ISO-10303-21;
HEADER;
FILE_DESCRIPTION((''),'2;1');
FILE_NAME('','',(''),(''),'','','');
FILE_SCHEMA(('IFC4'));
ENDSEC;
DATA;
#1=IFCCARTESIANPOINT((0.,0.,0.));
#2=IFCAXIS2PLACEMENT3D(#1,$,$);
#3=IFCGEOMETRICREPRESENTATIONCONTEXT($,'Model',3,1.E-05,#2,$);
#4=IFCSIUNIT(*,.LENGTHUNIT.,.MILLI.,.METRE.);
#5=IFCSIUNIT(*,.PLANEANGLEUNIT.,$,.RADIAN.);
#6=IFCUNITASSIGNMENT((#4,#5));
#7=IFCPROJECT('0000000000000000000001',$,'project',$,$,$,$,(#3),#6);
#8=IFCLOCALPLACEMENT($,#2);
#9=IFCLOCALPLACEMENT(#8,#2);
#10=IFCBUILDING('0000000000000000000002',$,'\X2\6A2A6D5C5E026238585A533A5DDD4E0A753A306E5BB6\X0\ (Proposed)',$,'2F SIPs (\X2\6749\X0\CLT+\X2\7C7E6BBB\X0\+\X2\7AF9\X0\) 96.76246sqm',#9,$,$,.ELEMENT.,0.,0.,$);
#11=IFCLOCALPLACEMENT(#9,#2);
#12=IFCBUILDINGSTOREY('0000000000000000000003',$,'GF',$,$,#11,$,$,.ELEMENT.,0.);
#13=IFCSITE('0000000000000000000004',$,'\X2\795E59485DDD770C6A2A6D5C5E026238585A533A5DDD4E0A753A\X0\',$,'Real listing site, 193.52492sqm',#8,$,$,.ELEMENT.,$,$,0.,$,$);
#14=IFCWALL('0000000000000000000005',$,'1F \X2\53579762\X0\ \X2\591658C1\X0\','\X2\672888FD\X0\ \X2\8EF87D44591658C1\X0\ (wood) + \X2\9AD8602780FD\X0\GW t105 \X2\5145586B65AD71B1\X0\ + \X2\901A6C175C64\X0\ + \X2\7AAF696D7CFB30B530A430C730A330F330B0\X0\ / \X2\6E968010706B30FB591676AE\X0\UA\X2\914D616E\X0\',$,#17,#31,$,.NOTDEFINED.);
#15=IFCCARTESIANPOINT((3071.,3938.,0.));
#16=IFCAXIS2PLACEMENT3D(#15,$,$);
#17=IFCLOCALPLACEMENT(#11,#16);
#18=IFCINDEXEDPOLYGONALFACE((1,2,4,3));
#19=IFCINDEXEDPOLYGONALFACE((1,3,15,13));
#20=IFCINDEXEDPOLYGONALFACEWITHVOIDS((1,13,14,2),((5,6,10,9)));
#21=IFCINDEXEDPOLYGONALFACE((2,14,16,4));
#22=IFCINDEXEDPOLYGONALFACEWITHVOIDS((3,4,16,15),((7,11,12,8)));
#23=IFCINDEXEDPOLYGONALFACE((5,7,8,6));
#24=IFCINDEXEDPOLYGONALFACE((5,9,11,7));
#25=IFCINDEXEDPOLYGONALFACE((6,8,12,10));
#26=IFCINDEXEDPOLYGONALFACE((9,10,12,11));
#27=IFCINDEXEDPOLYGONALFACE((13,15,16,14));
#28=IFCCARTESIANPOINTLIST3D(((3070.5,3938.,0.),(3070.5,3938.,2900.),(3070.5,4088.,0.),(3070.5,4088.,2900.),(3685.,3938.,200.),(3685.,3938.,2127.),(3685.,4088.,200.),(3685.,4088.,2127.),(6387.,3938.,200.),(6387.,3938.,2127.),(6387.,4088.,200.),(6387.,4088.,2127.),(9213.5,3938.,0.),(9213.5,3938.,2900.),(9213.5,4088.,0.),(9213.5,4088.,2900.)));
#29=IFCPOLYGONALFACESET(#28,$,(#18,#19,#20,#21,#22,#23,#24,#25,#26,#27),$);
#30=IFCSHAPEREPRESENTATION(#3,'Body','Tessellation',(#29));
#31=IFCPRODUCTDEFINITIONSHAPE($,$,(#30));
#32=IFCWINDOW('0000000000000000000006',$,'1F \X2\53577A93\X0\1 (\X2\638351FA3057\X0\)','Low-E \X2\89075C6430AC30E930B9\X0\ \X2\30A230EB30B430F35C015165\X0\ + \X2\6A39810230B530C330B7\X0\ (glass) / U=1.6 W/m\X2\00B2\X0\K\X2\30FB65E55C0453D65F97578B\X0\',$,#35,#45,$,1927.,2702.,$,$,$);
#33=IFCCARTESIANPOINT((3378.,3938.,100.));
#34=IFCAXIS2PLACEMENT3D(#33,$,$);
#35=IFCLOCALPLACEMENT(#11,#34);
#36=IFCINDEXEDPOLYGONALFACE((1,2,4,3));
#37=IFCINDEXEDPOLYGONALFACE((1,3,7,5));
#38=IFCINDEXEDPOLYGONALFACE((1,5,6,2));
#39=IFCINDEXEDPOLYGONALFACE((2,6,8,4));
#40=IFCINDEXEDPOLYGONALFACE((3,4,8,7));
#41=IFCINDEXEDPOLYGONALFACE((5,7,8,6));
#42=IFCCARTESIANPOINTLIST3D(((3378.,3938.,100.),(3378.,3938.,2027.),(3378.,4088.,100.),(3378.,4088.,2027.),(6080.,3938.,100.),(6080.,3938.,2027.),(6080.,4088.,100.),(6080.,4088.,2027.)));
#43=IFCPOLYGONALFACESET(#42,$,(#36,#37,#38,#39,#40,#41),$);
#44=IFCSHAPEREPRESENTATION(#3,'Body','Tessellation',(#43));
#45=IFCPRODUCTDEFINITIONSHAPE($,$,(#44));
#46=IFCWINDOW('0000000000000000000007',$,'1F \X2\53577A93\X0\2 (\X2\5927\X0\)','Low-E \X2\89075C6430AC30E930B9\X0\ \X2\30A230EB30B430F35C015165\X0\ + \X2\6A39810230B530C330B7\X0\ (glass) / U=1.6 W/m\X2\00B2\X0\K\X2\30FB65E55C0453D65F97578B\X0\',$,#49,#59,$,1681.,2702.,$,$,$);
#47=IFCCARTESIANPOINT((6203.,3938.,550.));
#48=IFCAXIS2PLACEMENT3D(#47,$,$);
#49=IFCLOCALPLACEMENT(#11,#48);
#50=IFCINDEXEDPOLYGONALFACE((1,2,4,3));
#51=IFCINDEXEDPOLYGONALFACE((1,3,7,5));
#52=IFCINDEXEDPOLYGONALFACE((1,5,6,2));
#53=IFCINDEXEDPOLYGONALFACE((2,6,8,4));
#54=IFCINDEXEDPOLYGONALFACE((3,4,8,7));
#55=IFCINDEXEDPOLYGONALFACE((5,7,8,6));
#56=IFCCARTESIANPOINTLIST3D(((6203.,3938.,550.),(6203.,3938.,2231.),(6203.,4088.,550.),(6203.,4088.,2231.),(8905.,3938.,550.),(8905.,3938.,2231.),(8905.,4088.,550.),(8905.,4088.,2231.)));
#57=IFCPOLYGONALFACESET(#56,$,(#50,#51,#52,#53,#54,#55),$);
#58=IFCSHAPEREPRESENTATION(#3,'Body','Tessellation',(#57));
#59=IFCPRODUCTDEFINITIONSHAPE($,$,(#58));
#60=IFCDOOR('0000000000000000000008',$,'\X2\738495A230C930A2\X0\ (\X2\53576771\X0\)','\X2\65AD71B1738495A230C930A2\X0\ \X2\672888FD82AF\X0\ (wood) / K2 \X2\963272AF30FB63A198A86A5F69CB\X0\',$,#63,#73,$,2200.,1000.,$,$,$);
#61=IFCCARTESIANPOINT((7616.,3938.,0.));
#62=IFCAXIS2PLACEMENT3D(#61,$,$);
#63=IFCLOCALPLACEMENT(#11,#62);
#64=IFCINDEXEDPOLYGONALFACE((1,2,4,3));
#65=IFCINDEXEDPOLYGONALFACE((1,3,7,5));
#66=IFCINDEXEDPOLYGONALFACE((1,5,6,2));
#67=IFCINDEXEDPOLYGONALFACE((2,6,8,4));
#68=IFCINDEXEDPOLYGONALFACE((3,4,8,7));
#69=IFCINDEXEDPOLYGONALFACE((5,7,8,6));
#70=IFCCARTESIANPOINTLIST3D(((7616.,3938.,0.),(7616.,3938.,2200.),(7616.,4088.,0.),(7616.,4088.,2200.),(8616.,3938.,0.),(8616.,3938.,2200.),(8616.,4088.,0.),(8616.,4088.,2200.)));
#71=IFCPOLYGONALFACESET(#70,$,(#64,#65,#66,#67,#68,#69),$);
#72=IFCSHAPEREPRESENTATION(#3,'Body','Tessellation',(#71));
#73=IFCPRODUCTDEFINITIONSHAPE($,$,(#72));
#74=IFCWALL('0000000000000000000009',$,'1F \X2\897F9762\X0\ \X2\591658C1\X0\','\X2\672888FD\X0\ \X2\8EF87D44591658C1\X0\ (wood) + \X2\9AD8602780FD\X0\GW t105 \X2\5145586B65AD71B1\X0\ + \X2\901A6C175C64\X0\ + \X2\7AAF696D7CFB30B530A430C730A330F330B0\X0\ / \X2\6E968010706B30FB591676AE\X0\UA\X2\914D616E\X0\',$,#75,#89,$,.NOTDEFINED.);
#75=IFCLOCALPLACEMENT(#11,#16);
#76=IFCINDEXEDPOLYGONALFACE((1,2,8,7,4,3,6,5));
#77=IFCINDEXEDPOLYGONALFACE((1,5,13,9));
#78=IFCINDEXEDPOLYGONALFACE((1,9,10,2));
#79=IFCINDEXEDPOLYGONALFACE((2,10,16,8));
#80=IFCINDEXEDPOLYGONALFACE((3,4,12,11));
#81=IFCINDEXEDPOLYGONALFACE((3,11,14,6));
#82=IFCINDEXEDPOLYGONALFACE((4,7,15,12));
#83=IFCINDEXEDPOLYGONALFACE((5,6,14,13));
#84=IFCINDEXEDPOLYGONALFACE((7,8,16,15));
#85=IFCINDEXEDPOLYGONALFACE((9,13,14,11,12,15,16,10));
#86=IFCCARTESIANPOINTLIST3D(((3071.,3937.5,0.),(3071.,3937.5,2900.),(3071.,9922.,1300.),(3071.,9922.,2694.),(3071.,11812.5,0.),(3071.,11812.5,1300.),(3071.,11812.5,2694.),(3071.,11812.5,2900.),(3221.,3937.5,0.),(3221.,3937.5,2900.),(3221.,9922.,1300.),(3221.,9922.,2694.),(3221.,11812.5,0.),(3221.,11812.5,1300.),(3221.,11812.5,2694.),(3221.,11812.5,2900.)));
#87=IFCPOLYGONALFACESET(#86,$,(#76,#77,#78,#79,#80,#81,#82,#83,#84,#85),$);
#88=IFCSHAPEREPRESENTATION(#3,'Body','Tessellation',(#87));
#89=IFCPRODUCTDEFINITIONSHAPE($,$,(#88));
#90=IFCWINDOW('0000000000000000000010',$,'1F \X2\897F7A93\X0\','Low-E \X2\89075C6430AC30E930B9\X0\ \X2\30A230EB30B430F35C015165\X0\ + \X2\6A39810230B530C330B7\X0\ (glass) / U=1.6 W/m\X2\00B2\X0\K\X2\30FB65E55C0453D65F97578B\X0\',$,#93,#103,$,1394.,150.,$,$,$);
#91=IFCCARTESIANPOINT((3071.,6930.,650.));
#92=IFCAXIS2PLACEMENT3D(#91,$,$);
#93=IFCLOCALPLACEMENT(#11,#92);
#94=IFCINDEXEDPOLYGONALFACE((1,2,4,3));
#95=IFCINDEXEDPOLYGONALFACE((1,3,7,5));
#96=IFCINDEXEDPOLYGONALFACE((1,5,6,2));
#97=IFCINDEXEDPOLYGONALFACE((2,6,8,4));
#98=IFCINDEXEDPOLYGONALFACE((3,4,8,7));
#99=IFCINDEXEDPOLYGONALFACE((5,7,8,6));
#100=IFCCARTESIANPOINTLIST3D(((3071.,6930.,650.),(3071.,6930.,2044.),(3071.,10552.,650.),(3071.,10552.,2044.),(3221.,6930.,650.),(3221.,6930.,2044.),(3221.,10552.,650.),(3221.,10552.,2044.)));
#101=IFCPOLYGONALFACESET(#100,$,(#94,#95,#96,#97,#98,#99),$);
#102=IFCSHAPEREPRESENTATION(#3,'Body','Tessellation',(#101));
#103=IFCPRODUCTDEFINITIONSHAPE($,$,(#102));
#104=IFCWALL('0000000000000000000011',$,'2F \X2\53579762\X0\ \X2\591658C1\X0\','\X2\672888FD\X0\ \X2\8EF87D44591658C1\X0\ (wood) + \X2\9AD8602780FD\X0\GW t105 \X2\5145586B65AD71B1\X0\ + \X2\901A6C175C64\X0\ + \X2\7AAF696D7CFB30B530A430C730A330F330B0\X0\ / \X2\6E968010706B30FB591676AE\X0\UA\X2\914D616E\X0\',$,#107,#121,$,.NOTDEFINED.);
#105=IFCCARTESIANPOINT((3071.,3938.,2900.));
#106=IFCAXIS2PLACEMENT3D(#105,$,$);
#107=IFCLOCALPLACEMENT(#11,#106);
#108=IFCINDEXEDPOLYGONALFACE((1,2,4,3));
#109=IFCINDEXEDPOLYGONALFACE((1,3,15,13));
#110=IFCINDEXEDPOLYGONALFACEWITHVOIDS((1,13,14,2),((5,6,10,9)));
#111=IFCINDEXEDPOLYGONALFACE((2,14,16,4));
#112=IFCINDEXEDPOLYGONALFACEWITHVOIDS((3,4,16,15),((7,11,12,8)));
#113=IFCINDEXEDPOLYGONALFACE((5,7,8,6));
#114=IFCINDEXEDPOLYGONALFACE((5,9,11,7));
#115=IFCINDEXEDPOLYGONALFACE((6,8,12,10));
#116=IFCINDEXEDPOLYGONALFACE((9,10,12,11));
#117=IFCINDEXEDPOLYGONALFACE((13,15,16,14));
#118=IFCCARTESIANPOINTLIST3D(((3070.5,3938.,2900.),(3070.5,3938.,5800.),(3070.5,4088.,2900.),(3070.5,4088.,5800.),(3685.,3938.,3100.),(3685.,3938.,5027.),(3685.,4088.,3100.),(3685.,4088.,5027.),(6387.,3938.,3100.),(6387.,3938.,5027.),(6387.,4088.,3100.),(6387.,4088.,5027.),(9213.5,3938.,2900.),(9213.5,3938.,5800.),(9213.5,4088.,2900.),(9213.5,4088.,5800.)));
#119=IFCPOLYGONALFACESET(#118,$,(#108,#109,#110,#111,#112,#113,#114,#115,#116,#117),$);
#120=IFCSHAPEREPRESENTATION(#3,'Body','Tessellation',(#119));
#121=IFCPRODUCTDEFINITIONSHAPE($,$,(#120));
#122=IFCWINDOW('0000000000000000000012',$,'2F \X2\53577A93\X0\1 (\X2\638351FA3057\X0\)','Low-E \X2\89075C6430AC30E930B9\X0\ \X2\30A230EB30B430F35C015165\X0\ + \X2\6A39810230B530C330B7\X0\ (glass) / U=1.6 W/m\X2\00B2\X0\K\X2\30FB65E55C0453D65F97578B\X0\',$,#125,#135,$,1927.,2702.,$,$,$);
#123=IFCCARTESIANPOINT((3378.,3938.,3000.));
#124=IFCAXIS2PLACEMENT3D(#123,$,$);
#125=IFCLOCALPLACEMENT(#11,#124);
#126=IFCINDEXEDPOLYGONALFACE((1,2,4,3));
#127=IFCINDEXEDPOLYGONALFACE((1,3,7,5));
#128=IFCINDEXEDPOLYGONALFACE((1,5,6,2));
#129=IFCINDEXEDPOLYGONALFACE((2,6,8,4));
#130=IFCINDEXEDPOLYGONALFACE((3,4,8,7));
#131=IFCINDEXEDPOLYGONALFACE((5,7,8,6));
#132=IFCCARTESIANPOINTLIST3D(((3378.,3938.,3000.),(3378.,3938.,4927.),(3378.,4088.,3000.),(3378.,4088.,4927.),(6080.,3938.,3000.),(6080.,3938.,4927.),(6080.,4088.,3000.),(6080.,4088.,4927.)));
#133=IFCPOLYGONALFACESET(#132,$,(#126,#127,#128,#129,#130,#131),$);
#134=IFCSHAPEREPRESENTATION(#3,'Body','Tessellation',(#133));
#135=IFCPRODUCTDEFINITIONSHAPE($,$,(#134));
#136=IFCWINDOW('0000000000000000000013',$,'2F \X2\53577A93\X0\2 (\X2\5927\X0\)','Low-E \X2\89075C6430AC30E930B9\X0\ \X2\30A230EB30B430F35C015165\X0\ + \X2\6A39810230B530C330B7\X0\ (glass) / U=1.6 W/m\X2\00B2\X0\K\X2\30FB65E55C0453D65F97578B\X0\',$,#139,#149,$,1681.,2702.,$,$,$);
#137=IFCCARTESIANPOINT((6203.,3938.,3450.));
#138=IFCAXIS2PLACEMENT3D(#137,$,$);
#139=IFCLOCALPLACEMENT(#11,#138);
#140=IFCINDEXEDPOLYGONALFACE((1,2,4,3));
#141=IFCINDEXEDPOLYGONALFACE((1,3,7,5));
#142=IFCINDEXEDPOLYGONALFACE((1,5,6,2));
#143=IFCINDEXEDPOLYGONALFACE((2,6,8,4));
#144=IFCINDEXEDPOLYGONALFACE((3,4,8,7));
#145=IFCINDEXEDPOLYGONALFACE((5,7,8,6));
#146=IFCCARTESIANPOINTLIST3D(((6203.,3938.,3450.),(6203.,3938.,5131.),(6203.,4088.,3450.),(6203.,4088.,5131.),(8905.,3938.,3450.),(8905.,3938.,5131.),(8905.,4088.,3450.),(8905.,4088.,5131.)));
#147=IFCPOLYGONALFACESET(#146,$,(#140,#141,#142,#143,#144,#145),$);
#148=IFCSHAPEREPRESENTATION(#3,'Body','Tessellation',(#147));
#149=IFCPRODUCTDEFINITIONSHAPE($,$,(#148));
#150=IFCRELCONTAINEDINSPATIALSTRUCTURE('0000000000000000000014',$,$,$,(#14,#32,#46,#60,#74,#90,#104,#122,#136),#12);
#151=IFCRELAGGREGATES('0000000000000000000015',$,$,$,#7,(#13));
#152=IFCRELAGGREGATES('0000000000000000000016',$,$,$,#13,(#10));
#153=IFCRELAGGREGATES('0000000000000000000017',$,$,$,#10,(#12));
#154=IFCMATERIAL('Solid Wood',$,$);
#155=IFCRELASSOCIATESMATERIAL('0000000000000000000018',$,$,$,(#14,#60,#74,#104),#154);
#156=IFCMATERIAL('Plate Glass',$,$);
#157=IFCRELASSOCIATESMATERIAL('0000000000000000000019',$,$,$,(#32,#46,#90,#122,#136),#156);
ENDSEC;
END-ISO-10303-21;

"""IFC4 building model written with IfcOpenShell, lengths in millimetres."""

from ifc_helpers import new_model, si_unit, frame, frame_2d, origin, place, context, project, spatial, rectangle, extrude, material, element, fill, save


model = new_model("IFC4")

# Units and contexts
model_context = context("Model", 3, precision=1e-05, world=origin())
ifc_project = project(units=[si_unit("LENGTHUNIT", "METRE", prefix="MILLI"), si_unit("PLANEANGLEUNIT", "RADIAN")], contexts=[model_context])

# Site, building, storey
site_placement = place(None, origin())
site = spatial("IfcSite", under=ifc_project, at=site_placement, Name="神奈川県横浜市戸塚区川上町", ObjectType="Real listing site, 193.52492sqm", CompositionType="ELEMENT", RefElevation=0.0)
building_placement = place(site_placement, origin())
building = spatial("IfcBuilding", under=site, at=building_placement, Name="横浜市戸塚区川上町の家 (Proposed)", ObjectType="2F SIPs (杉CLT+籾殻+竹) 96.76246sqm", CompositionType="ELEMENT", ElevationOfRefHeight=0.0, ElevationOfTerrain=0.0)
storey_placement = place(building_placement, origin())
storey = spatial("IfcBuildingStorey", under=building, at=storey_placement, Name="GF", CompositionType="ELEMENT", Elevation=0.0)

# Shared definitions
ifc_material_1 = material(Name="Solid Wood")

# Wall, openings, windows, door
wall_1_placement = place(storey_placement, frame((3071.0, 3938.0, 0.0)))
wall_1 = element("IfcWall", 1, at=wall_1_placement, inside=storey, material=ifc_material_1, Name="1F 南面 外壁", Description="木製 軸組外壁 (wood) + 高性能GW t105 充填断熱 + 通気層 + 窯業系サイディング / 準耐火・外皮UA配慮", PredefinedType="NOTDEFINED", context=model_context, shape_type="SweptSolid", body=[
    extrude(rectangle(XDim=6143.0, YDim=150.0, at=frame_2d((3071.0, 75.0))), frame((3071.0, 3938.0, 0.0)), (0.0, 0.0, 1.0), 2900.0),
])
opening_1_placement = place(storey_placement, frame((3378.0, 3938.0, 100.0)))
opening_1 = element("IfcOpeningElement", 2, at=opening_1_placement, cuts=wall_1, PredefinedType="NOTDEFINED", context=model_context, shape_type="SweptSolid", body=[
    extrude(rectangle(XDim=2702.0, YDim=150.0, at=frame_2d((1351.0, 75.0))), frame((3378.0, 3938.0, 100.0)), (0.0, 0.0, 1.0), 1927.0),
])
opening_2_placement = place(storey_placement, frame((6203.0, 3938.0, 550.0)))
opening_2 = element("IfcOpeningElement", 3, at=opening_2_placement, cuts=wall_1, PredefinedType="NOTDEFINED", context=model_context, shape_type="SweptSolid", body=[
    extrude(rectangle(XDim=2702.0, YDim=150.0, at=frame_2d((1351.0, 75.0))), frame((6203.0, 3938.0, 550.0)), (0.0, 0.0, 1.0), 1681.0),
])
opening_3_placement = place(storey_placement, frame((7616.0, 3938.0, 0.0)))
opening_3 = element("IfcOpeningElement", 4, at=opening_3_placement, cuts=wall_1, PredefinedType="NOTDEFINED", context=model_context, shape_type="SweptSolid", body=[
    extrude(rectangle(XDim=1000.0, YDim=150.0, at=frame_2d((500.0, 75.0))), frame((7616.0, 3938.0, 0.0)), (0.0, 0.0, 1.0), 2200.0),
])
ifc_material_2 = material(Name="Plate Glass")
window_1_placement = place(storey_placement, frame((3378.0, 3938.0, 100.0)))
window_1 = element("IfcWindow", 5, at=window_1_placement, inside=storey, material=ifc_material_2, Name="1F 南窓1 (掃出し)", Description="Low-E 複層ガラス アルゴン封入 + 樹脂サッシ (glass) / U=1.6 W/m²K・日射取得型", OverallHeight=1927.0, OverallWidth=2702.0, context=model_context, shape_type="SweptSolid", body=[
    extrude(rectangle(XDim=2702.0, YDim=150.0, at=frame_2d((1351.0, 75.0))), frame((3378.0, 3938.0, 100.0)), (0.0, 0.0, 1.0), 1927.0),
])
fill(opening_1, window_1)
window_2_placement = place(storey_placement, frame((6203.0, 3938.0, 550.0)))
window_2 = element("IfcWindow", 6, at=window_2_placement, inside=storey, material=ifc_material_2, Name="1F 南窓2 (大)", Description="Low-E 複層ガラス アルゴン封入 + 樹脂サッシ (glass) / U=1.6 W/m²K・日射取得型", OverallHeight=1681.0, OverallWidth=2702.0, context=model_context, shape_type="SweptSolid", body=[
    extrude(rectangle(XDim=2702.0, YDim=150.0, at=frame_2d((1351.0, 75.0))), frame((6203.0, 3938.0, 550.0)), (0.0, 0.0, 1.0), 1681.0),
])
fill(opening_2, window_2)
door_placement = place(storey_placement, frame((7616.0, 3938.0, 0.0)))
door = element("IfcDoor", 7, at=door_placement, inside=storey, material=ifc_material_1, Name="玄関ドア (南東)", Description="断熱玄関ドア 木製芯 (wood) / K2 防犯・採風機構", OverallHeight=2200.0, OverallWidth=1000.0, context=model_context, shape_type="SweptSolid", body=[
    extrude(rectangle(XDim=1000.0, YDim=150.0, at=frame_2d((500.0, 75.0))), frame((7616.0, 3938.0, 0.0)), (0.0, 0.0, 1.0), 2200.0),
])
fill(opening_3, door)

# Wall, opening, window
wall_2_placement = place(storey_placement, frame((3071.0, 3938.0, 0.0)))
wall_2 = element("IfcWall", 8, at=wall_2_placement, inside=storey, material=ifc_material_1, Name="1F 西面 外壁", Description="木製 軸組外壁 (wood) + 高性能GW t105 充填断熱 + 通気層 + 窯業系サイディング / 準耐火・外皮UA配慮", PredefinedType="NOTDEFINED", context=model_context, shape_type="SweptSolid", body=[
    extrude(rectangle(XDim=150.0, YDim=7875.0, at=frame_2d((75.0, 3937.0))), frame((3071.0, 3938.0, 0.0)), (0.0, 0.0, 1.0), 2900.0),
])
opening_4_placement = place(storey_placement, frame((3071.0, 6930.0, 650.0)))
opening_4 = element("IfcOpeningElement", 9, at=opening_4_placement, cuts=wall_2, PredefinedType="NOTDEFINED", context=model_context, shape_type="SweptSolid", body=[
    extrude(rectangle(XDim=150.0, YDim=3622.0, at=frame_2d((75.0, 1811.0))), frame((3071.0, 6930.0, 650.0)), (0.0, 0.0, 1.0), 1394.0),
])
window_3_placement = place(storey_placement, frame((3071.0, 6930.0, 650.0)))
window_3 = element("IfcWindow", 10, at=window_3_placement, inside=storey, material=ifc_material_2, Name="1F 西窓", Description="Low-E 複層ガラス アルゴン封入 + 樹脂サッシ (glass) / U=1.6 W/m²K・日射取得型", OverallHeight=1394.0, OverallWidth=150.0, context=model_context, shape_type="SweptSolid", body=[
    extrude(rectangle(XDim=150.0, YDim=3622.0, at=frame_2d((75.0, 1811.0))), frame((3071.0, 6930.0, 650.0)), (0.0, 0.0, 1.0), 1394.0),
])
fill(opening_4, window_3)

# Wall, openings, windows
wall_3_placement = place(storey_placement, frame((3071.0, 3938.0, 2900.0)))
wall_3 = element("IfcWall", 11, at=wall_3_placement, inside=storey, material=ifc_material_1, Name="2F 南面 外壁", Description="木製 軸組外壁 (wood) + 高性能GW t105 充填断熱 + 通気層 + 窯業系サイディング / 準耐火・外皮UA配慮", PredefinedType="NOTDEFINED", context=model_context, shape_type="SweptSolid", body=[
    extrude(rectangle(XDim=6143.0, YDim=150.0, at=frame_2d((3071.0, 75.0))), frame((3071.0, 3938.0, 2900.0)), (0.0, 0.0, 1.0), 2900.0),
])
opening_5_placement = place(storey_placement, frame((3378.0, 3938.0, 3000.0)))
opening_5 = element("IfcOpeningElement", 12, at=opening_5_placement, cuts=wall_3, PredefinedType="NOTDEFINED", context=model_context, shape_type="SweptSolid", body=[
    extrude(rectangle(XDim=2702.0, YDim=150.0, at=frame_2d((1351.0, 75.0))), frame((3378.0, 3938.0, 3000.0)), (0.0, 0.0, 1.0), 1927.0),
])
opening_6_placement = place(storey_placement, frame((6203.0, 3938.0, 3450.0)))
opening_6 = element("IfcOpeningElement", 13, at=opening_6_placement, cuts=wall_3, PredefinedType="NOTDEFINED", context=model_context, shape_type="SweptSolid", body=[
    extrude(rectangle(XDim=2702.0, YDim=150.0, at=frame_2d((1351.0, 75.0))), frame((6203.0, 3938.0, 3450.0)), (0.0, 0.0, 1.0), 1681.0),
])
window_4_placement = place(storey_placement, frame((3378.0, 3938.0, 3000.0)))
window_4 = element("IfcWindow", 14, at=window_4_placement, inside=storey, material=ifc_material_2, Name="2F 南窓1 (掃出し)", Description="Low-E 複層ガラス アルゴン封入 + 樹脂サッシ (glass) / U=1.6 W/m²K・日射取得型", OverallHeight=1927.0, OverallWidth=2702.0, context=model_context, shape_type="SweptSolid", body=[
    extrude(rectangle(XDim=2702.0, YDim=150.0, at=frame_2d((1351.0, 75.0))), frame((3378.0, 3938.0, 3000.0)), (0.0, 0.0, 1.0), 1927.0),
])
fill(opening_5, window_4)
window_5_placement = place(storey_placement, frame((6203.0, 3938.0, 3450.0)))
window_5 = element("IfcWindow", 15, at=window_5_placement, inside=storey, material=ifc_material_2, Name="2F 南窓2 (大)", Description="Low-E 複層ガラス アルゴン封入 + 樹脂サッシ (glass) / U=1.6 W/m²K・日射取得型", OverallHeight=1681.0, OverallWidth=2702.0, context=model_context, shape_type="SweptSolid", body=[
    extrude(rectangle(XDim=2702.0, YDim=150.0, at=frame_2d((1351.0, 75.0))), frame((6203.0, 3938.0, 3450.0)), (0.0, 0.0, 1.0), 1681.0),
])
fill(opening_6, window_5)

save(model, "model.ifc")
